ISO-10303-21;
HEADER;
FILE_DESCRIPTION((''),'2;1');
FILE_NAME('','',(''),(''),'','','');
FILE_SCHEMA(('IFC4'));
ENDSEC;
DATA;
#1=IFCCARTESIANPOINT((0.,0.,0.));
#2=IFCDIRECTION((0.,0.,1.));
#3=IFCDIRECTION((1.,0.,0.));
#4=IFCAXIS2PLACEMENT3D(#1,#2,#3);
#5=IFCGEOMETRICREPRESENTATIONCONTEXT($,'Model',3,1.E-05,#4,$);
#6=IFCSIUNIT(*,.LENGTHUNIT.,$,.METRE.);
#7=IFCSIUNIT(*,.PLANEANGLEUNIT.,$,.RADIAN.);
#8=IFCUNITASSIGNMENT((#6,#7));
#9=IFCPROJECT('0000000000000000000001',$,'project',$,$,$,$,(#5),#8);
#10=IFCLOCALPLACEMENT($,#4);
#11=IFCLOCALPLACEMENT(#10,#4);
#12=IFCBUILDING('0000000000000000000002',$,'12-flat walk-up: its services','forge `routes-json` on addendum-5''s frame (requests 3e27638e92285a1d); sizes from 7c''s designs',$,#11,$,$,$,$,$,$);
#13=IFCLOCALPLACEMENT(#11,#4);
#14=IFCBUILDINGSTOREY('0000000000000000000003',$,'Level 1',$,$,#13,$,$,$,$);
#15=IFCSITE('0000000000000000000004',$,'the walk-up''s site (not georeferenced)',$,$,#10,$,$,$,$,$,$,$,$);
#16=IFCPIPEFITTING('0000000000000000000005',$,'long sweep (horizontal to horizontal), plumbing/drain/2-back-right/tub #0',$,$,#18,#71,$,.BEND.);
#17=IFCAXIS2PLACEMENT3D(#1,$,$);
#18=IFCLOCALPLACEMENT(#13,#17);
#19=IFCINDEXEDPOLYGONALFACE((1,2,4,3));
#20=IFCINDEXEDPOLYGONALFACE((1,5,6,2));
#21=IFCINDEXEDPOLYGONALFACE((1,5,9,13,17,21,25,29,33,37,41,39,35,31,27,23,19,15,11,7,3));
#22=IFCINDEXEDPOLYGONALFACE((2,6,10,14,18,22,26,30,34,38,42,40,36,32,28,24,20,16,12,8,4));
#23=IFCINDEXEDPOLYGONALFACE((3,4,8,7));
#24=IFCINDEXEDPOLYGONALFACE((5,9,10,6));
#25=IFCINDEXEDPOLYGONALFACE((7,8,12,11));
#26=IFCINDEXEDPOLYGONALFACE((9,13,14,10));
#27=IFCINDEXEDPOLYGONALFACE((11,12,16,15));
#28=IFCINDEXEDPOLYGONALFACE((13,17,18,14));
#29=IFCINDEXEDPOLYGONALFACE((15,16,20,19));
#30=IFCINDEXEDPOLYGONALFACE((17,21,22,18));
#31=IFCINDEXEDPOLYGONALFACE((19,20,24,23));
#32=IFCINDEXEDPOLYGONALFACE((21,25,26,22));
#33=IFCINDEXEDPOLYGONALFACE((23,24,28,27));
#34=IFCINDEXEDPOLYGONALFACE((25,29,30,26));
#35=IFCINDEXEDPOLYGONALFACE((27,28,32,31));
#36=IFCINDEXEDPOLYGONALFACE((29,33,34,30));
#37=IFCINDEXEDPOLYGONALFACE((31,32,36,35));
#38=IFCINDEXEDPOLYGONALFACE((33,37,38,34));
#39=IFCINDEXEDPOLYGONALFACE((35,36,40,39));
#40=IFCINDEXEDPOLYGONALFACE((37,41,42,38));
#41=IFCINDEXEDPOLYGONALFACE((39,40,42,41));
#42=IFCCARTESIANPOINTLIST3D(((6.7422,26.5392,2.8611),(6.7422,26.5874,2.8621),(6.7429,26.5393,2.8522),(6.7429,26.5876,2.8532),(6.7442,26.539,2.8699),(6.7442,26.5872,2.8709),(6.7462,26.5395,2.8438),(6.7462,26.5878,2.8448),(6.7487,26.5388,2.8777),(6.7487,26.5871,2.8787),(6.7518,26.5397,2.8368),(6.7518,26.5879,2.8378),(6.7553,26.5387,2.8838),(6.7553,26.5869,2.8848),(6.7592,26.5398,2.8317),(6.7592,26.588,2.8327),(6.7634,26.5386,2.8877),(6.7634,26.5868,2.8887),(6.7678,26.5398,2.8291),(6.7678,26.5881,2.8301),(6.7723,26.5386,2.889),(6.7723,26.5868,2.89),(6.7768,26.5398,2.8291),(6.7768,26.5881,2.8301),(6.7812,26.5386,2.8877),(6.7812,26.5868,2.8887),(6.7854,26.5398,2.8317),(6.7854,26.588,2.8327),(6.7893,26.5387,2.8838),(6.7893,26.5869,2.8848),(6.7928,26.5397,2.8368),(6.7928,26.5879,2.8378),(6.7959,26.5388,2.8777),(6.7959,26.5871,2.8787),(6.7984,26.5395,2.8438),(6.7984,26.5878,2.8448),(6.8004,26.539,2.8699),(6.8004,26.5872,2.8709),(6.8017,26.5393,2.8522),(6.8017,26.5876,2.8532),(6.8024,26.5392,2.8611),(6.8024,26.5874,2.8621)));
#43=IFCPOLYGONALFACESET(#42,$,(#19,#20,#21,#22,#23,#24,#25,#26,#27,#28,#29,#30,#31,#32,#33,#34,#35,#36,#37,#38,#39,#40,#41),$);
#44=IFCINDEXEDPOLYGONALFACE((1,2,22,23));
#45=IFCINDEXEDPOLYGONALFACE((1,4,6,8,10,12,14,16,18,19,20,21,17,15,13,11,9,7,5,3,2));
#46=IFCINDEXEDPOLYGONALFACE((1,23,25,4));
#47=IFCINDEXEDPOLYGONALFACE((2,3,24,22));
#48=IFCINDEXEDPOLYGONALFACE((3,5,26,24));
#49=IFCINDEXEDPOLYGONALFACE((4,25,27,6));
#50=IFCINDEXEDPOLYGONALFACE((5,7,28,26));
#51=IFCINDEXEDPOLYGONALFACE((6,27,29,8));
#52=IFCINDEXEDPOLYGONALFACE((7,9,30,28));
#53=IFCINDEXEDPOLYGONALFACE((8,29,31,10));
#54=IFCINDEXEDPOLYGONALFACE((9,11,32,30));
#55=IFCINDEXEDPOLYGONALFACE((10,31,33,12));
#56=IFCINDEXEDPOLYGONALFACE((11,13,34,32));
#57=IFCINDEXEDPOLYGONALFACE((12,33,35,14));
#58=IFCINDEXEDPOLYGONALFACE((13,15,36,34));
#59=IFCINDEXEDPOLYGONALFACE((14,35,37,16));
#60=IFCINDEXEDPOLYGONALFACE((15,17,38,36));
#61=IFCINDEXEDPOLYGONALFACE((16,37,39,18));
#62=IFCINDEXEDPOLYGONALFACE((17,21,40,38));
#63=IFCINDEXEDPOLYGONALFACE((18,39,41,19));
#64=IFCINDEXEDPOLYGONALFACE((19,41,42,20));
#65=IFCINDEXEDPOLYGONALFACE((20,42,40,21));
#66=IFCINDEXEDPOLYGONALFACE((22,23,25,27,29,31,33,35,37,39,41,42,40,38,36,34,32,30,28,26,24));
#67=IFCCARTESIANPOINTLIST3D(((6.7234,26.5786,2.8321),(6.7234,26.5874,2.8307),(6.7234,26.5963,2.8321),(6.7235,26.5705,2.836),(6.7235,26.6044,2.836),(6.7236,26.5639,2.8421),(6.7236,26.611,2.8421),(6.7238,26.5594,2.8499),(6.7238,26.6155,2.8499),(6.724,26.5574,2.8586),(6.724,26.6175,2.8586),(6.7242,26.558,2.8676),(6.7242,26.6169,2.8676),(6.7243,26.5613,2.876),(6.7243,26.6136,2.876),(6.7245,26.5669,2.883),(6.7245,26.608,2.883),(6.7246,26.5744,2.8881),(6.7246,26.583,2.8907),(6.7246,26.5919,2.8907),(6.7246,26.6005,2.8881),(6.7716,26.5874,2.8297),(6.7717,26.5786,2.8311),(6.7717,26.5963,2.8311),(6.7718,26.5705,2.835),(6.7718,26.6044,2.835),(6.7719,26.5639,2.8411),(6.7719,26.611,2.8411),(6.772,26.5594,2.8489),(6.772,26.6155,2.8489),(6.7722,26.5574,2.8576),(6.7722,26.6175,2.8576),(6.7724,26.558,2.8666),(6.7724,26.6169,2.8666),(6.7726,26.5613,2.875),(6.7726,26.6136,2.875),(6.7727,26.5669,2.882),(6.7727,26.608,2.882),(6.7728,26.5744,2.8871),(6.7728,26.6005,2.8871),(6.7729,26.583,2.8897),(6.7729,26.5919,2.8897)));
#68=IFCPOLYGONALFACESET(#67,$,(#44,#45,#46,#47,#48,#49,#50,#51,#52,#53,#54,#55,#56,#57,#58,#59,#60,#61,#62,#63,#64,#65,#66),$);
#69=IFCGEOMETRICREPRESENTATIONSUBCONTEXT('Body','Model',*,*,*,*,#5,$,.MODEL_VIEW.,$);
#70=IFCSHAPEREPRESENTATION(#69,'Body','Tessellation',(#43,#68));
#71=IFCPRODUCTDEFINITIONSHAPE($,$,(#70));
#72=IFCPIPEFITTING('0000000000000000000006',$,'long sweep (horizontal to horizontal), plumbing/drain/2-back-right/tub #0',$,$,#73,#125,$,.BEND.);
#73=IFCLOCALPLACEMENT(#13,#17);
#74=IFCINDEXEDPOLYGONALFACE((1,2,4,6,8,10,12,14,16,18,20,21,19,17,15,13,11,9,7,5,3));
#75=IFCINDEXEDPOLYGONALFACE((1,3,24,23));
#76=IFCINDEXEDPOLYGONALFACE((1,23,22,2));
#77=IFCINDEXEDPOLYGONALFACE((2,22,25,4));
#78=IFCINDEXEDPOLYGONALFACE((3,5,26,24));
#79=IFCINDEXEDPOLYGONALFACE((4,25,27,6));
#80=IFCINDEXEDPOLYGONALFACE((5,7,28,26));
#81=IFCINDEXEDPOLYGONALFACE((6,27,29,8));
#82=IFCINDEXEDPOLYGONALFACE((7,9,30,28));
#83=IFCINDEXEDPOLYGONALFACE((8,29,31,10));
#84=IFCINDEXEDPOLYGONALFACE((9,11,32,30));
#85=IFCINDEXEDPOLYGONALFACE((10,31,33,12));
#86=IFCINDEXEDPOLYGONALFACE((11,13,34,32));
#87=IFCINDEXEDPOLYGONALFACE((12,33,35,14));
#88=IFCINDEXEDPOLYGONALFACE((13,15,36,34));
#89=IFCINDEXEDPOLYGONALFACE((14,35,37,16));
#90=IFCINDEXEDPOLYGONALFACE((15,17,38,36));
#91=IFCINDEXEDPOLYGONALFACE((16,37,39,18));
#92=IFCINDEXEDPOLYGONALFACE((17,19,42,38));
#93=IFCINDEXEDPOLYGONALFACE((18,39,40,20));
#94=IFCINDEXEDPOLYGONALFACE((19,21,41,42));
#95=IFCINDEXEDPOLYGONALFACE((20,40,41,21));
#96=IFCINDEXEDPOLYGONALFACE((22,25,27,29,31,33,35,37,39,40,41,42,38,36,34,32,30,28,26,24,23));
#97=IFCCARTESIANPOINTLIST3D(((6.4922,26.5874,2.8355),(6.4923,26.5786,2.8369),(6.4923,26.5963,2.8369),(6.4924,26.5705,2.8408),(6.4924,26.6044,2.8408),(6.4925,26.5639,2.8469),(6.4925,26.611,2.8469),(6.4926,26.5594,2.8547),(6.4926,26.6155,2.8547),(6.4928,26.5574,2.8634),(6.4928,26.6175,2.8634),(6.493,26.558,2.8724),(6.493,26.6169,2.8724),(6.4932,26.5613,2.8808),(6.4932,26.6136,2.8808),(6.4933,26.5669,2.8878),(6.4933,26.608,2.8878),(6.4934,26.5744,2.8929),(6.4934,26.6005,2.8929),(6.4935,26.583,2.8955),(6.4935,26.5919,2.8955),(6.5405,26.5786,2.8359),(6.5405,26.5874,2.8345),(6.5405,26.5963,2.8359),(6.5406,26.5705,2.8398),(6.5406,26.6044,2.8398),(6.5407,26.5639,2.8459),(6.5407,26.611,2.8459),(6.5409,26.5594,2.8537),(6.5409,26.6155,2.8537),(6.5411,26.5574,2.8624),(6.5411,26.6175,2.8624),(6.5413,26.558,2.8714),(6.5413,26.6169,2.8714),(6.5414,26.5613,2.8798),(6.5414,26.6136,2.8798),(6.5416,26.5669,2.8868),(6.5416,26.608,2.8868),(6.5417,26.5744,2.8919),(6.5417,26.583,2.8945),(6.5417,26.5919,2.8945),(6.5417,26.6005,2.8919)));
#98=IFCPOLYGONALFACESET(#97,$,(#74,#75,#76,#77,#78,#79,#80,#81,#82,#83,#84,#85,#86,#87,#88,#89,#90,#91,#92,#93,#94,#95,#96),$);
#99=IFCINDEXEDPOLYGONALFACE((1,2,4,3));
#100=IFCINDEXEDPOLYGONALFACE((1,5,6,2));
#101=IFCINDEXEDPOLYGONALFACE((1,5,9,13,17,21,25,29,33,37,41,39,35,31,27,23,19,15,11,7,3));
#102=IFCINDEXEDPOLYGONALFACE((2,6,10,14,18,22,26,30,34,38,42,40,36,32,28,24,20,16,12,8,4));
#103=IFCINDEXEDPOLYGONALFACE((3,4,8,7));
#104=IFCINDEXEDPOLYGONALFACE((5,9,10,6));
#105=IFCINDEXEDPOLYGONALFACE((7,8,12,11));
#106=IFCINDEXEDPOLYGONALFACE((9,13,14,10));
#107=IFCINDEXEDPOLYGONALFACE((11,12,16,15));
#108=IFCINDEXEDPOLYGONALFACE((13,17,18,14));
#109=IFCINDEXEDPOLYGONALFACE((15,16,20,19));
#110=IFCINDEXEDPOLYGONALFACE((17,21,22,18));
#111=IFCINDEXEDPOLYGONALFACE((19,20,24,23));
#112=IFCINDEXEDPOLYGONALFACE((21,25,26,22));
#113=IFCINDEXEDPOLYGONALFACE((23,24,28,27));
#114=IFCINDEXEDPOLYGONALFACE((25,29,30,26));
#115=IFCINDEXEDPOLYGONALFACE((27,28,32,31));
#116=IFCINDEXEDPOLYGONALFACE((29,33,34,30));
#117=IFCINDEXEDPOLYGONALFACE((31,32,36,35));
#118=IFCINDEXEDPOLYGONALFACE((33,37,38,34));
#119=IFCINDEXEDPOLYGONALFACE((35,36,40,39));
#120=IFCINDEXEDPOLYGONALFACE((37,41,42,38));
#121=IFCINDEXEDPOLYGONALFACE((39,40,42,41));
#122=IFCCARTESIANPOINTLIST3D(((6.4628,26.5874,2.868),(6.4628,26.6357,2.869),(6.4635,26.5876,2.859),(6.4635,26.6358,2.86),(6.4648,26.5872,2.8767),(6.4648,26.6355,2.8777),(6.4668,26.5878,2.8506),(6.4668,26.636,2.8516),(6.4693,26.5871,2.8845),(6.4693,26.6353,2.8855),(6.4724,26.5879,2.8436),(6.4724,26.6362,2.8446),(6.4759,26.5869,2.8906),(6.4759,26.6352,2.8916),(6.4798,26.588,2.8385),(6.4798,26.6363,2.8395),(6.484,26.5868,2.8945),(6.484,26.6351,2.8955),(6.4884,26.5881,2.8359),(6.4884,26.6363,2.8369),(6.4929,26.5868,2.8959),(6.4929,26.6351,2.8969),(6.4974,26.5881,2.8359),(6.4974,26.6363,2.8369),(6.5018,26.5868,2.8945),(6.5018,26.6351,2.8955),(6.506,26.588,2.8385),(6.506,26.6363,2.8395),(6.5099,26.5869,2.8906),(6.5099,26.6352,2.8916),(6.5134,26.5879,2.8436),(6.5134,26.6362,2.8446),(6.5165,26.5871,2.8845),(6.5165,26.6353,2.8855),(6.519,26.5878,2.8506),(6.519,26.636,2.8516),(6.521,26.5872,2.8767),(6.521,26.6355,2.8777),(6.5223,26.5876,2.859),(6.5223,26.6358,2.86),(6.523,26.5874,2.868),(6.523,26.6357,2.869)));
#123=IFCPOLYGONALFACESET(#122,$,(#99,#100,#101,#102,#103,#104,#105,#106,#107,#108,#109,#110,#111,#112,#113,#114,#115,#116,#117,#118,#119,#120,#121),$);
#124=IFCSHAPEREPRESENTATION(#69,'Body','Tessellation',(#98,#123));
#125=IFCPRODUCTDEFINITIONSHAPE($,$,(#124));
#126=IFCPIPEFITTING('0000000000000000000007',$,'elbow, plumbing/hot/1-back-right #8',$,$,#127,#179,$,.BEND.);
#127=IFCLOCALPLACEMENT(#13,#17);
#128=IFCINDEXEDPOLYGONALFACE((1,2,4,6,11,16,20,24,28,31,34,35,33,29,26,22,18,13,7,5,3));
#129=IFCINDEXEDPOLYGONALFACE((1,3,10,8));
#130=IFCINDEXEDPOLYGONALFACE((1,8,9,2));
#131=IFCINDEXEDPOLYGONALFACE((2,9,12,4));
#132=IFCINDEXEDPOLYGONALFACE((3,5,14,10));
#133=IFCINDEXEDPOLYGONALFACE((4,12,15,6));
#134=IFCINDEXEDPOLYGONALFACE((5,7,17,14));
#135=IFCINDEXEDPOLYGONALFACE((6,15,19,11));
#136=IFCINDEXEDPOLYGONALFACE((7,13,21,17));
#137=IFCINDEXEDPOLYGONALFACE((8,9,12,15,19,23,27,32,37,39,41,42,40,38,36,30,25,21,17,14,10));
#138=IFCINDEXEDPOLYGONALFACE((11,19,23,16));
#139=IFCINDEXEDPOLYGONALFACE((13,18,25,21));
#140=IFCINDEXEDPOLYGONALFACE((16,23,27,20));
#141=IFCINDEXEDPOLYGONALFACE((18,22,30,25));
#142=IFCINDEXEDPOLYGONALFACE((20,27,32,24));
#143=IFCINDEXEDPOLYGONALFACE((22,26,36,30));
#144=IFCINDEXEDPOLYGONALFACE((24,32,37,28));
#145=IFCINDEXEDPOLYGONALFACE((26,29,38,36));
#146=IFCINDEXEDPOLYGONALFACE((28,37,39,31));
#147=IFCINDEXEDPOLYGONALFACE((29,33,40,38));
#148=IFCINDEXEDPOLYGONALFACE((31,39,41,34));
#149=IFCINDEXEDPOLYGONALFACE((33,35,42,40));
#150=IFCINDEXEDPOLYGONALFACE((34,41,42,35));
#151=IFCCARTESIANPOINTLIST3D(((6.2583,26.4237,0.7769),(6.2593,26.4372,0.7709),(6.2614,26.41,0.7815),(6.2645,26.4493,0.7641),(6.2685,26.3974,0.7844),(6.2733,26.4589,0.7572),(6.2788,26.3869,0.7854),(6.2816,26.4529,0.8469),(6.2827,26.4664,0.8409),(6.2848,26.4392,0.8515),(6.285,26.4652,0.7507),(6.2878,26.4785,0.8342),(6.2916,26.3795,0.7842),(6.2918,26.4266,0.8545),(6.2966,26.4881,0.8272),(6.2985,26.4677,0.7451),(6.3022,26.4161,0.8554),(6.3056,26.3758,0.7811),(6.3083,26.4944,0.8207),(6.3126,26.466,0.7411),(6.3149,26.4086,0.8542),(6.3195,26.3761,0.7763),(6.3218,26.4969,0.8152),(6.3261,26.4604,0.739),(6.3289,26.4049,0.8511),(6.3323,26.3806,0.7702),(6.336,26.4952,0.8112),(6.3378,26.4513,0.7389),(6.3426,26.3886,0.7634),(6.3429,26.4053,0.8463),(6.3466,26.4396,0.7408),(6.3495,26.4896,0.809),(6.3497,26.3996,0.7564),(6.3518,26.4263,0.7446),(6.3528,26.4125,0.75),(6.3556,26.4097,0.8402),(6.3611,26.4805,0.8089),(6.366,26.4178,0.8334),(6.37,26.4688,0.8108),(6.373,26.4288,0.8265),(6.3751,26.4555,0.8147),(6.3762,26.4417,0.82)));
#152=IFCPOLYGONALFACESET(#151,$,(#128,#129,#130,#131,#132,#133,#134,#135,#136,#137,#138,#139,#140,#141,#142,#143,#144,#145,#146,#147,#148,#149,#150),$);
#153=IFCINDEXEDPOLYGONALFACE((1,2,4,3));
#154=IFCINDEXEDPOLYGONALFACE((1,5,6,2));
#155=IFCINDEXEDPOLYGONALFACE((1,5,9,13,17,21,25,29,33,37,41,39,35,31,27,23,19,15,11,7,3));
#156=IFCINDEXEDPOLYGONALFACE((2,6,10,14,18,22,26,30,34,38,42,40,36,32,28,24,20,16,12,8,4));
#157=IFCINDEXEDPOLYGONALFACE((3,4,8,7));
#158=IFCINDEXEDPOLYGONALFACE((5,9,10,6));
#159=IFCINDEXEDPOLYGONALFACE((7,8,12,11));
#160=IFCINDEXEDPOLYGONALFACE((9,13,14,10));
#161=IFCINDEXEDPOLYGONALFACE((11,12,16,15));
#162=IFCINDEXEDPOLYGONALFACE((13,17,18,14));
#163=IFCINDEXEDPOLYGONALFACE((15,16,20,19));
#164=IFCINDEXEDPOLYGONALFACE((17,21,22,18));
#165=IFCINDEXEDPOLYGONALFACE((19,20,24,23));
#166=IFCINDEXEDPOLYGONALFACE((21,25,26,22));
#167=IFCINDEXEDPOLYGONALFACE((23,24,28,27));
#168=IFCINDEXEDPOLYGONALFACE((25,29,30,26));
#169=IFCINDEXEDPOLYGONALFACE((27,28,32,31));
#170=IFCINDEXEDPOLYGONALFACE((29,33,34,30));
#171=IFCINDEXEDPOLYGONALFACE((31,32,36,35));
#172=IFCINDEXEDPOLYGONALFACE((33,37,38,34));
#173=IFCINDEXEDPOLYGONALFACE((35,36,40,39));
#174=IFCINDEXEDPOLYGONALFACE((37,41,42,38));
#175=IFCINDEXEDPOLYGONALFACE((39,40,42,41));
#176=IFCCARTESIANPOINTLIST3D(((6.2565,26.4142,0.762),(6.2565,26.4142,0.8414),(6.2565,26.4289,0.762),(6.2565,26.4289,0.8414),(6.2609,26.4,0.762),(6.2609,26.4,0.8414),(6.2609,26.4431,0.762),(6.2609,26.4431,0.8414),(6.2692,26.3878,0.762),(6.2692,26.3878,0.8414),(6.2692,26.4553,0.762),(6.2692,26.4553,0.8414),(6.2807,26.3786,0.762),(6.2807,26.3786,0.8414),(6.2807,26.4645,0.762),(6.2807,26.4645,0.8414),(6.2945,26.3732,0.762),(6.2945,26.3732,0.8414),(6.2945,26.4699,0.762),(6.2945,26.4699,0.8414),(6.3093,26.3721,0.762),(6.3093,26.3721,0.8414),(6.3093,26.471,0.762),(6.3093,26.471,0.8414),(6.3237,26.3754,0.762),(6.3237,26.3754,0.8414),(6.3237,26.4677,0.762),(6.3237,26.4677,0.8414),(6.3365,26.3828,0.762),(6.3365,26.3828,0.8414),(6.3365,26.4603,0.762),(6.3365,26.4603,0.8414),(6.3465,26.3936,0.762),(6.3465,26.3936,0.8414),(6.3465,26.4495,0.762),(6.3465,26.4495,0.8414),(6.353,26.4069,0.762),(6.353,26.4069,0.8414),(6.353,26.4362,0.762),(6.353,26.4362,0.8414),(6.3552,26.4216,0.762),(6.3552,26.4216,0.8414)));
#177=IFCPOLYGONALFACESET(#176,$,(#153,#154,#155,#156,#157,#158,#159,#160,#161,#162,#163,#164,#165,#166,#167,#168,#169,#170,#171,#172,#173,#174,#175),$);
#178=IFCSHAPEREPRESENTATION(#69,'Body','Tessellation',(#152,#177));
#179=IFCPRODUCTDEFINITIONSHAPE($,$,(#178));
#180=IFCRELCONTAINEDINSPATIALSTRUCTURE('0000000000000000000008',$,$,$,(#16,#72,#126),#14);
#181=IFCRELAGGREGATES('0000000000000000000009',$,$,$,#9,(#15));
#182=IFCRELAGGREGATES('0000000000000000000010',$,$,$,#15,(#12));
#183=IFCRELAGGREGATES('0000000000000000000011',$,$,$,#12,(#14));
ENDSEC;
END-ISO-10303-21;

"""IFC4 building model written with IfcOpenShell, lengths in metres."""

from ifc_helpers import new_model, entity, si_unit, frame, origin_with_axes, place, context, subcontext, project, spatial, element, save


model = new_model("IFC4")

# Units and contexts
model_context = context("Model", 3, precision=1e-05, world=origin_with_axes())
body_context = subcontext(model_context, "Body", "Model", "MODEL_VIEW")
ifc_project = project(units=[si_unit("LENGTHUNIT", "METRE"), si_unit("PLANEANGLEUNIT", "RADIAN")], contexts=[model_context])

# Site, building, storey
site_placement = place(None, origin_with_axes())
site = spatial("IfcSite", under=ifc_project, at=site_placement, Name="the walk-up's site (not georeferenced)")
building_placement = place(site_placement, origin_with_axes())
building = spatial("IfcBuilding", under=site, at=building_placement, Name="12-flat walk-up: its services", Description="forge `routes-json` on addendum-5's frame (requests 3e27638e92285a1d); sizes from 7c's designs")
storey_placement = place(building_placement, origin_with_axes())
storey = spatial("IfcBuildingStorey", under=building, at=storey_placement, Name="Level 1")

# Pipe fittings
pipe_fitting_1_placement = place(storey_placement, frame((6.7723, 26.5392, 2.8589), z_axis=(0.0, 0.0, 1.0), x_axis=(1.0, 0.0, 0.0)))
element("IfcPipeFitting", 1, at=pipe_fitting_1_placement, inside=storey, Name="long sweep (horizontal to horizontal), plumbing/drain/2-back-right/tub #0", PredefinedType="BEND", context=body_context, shape_type="AdvancedSweptSolid", body=[
    entity("IfcSweptDiskSolid", entity("IfcPolyline", [entity("IfcCartesianPoint", [0.0, 0.0, 0.0]), entity("IfcCartesianPoint", [0.0, 0.0482, 0.001])]), 0.0302),
    entity("IfcSweptDiskSolid", entity("IfcPolyline", [entity("IfcCartesianPoint", [0.0, 0.0482, 0.001]), entity("IfcCartesianPoint", [-0.0482, 0.0482, 0.002])]), 0.0302),
])
pipe_fitting_2_placement = place(storey_placement, frame((6.5411, 26.5875, 2.8647), z_axis=(0.0, 0.0, 1.0), x_axis=(1.0, 0.0, 0.0)))
element("IfcPipeFitting", 2, at=pipe_fitting_2_placement, inside=storey, Name="long sweep (horizontal to horizontal), plumbing/drain/2-back-right/tub #0", PredefinedType="BEND", context=body_context, shape_type="AdvancedSweptSolid", body=[
    entity("IfcSweptDiskSolid", entity("IfcPolyline", [entity("IfcCartesianPoint", [0.0, 0.0, 0.0]), entity("IfcCartesianPoint", [-0.0482, 0.0, 0.001])]), 0.0302),
    entity("IfcSweptDiskSolid", entity("IfcPolyline", [entity("IfcCartesianPoint", [-0.0482, 0.0, 0.001]), entity("IfcCartesianPoint", [-0.0482, 0.0482, 0.002])]), 0.0302),
])
pipe_fitting_3_placement = place(storey_placement, frame((6.3289, 26.4507, 0.832), z_axis=(0.0, 0.0, 1.0), x_axis=(1.0, 0.0, 0.0)))
element("IfcPipeFitting", 3, at=pipe_fitting_3_placement, inside=storey, Name="elbow, plumbing/hot/1-back-right #8", PredefinedType="BEND", context=body_context, shape_type="AdvancedSweptSolid", body=[
    entity("IfcSweptDiskSolid", entity("IfcPolyline", [entity("IfcCartesianPoint", [0.0, 0.0, 0.0]), entity("IfcCartesianPoint", [-0.0233, -0.0292, -0.07])]), 0.0496),
    entity("IfcSweptDiskSolid", entity("IfcPolyline", [entity("IfcCartesianPoint", [-0.0233, -0.0292, -0.07]), entity("IfcCartesianPoint", [-0.0233, -0.0292, 0.0093])]), 0.0496),
])

save(model, "model.ifc")
